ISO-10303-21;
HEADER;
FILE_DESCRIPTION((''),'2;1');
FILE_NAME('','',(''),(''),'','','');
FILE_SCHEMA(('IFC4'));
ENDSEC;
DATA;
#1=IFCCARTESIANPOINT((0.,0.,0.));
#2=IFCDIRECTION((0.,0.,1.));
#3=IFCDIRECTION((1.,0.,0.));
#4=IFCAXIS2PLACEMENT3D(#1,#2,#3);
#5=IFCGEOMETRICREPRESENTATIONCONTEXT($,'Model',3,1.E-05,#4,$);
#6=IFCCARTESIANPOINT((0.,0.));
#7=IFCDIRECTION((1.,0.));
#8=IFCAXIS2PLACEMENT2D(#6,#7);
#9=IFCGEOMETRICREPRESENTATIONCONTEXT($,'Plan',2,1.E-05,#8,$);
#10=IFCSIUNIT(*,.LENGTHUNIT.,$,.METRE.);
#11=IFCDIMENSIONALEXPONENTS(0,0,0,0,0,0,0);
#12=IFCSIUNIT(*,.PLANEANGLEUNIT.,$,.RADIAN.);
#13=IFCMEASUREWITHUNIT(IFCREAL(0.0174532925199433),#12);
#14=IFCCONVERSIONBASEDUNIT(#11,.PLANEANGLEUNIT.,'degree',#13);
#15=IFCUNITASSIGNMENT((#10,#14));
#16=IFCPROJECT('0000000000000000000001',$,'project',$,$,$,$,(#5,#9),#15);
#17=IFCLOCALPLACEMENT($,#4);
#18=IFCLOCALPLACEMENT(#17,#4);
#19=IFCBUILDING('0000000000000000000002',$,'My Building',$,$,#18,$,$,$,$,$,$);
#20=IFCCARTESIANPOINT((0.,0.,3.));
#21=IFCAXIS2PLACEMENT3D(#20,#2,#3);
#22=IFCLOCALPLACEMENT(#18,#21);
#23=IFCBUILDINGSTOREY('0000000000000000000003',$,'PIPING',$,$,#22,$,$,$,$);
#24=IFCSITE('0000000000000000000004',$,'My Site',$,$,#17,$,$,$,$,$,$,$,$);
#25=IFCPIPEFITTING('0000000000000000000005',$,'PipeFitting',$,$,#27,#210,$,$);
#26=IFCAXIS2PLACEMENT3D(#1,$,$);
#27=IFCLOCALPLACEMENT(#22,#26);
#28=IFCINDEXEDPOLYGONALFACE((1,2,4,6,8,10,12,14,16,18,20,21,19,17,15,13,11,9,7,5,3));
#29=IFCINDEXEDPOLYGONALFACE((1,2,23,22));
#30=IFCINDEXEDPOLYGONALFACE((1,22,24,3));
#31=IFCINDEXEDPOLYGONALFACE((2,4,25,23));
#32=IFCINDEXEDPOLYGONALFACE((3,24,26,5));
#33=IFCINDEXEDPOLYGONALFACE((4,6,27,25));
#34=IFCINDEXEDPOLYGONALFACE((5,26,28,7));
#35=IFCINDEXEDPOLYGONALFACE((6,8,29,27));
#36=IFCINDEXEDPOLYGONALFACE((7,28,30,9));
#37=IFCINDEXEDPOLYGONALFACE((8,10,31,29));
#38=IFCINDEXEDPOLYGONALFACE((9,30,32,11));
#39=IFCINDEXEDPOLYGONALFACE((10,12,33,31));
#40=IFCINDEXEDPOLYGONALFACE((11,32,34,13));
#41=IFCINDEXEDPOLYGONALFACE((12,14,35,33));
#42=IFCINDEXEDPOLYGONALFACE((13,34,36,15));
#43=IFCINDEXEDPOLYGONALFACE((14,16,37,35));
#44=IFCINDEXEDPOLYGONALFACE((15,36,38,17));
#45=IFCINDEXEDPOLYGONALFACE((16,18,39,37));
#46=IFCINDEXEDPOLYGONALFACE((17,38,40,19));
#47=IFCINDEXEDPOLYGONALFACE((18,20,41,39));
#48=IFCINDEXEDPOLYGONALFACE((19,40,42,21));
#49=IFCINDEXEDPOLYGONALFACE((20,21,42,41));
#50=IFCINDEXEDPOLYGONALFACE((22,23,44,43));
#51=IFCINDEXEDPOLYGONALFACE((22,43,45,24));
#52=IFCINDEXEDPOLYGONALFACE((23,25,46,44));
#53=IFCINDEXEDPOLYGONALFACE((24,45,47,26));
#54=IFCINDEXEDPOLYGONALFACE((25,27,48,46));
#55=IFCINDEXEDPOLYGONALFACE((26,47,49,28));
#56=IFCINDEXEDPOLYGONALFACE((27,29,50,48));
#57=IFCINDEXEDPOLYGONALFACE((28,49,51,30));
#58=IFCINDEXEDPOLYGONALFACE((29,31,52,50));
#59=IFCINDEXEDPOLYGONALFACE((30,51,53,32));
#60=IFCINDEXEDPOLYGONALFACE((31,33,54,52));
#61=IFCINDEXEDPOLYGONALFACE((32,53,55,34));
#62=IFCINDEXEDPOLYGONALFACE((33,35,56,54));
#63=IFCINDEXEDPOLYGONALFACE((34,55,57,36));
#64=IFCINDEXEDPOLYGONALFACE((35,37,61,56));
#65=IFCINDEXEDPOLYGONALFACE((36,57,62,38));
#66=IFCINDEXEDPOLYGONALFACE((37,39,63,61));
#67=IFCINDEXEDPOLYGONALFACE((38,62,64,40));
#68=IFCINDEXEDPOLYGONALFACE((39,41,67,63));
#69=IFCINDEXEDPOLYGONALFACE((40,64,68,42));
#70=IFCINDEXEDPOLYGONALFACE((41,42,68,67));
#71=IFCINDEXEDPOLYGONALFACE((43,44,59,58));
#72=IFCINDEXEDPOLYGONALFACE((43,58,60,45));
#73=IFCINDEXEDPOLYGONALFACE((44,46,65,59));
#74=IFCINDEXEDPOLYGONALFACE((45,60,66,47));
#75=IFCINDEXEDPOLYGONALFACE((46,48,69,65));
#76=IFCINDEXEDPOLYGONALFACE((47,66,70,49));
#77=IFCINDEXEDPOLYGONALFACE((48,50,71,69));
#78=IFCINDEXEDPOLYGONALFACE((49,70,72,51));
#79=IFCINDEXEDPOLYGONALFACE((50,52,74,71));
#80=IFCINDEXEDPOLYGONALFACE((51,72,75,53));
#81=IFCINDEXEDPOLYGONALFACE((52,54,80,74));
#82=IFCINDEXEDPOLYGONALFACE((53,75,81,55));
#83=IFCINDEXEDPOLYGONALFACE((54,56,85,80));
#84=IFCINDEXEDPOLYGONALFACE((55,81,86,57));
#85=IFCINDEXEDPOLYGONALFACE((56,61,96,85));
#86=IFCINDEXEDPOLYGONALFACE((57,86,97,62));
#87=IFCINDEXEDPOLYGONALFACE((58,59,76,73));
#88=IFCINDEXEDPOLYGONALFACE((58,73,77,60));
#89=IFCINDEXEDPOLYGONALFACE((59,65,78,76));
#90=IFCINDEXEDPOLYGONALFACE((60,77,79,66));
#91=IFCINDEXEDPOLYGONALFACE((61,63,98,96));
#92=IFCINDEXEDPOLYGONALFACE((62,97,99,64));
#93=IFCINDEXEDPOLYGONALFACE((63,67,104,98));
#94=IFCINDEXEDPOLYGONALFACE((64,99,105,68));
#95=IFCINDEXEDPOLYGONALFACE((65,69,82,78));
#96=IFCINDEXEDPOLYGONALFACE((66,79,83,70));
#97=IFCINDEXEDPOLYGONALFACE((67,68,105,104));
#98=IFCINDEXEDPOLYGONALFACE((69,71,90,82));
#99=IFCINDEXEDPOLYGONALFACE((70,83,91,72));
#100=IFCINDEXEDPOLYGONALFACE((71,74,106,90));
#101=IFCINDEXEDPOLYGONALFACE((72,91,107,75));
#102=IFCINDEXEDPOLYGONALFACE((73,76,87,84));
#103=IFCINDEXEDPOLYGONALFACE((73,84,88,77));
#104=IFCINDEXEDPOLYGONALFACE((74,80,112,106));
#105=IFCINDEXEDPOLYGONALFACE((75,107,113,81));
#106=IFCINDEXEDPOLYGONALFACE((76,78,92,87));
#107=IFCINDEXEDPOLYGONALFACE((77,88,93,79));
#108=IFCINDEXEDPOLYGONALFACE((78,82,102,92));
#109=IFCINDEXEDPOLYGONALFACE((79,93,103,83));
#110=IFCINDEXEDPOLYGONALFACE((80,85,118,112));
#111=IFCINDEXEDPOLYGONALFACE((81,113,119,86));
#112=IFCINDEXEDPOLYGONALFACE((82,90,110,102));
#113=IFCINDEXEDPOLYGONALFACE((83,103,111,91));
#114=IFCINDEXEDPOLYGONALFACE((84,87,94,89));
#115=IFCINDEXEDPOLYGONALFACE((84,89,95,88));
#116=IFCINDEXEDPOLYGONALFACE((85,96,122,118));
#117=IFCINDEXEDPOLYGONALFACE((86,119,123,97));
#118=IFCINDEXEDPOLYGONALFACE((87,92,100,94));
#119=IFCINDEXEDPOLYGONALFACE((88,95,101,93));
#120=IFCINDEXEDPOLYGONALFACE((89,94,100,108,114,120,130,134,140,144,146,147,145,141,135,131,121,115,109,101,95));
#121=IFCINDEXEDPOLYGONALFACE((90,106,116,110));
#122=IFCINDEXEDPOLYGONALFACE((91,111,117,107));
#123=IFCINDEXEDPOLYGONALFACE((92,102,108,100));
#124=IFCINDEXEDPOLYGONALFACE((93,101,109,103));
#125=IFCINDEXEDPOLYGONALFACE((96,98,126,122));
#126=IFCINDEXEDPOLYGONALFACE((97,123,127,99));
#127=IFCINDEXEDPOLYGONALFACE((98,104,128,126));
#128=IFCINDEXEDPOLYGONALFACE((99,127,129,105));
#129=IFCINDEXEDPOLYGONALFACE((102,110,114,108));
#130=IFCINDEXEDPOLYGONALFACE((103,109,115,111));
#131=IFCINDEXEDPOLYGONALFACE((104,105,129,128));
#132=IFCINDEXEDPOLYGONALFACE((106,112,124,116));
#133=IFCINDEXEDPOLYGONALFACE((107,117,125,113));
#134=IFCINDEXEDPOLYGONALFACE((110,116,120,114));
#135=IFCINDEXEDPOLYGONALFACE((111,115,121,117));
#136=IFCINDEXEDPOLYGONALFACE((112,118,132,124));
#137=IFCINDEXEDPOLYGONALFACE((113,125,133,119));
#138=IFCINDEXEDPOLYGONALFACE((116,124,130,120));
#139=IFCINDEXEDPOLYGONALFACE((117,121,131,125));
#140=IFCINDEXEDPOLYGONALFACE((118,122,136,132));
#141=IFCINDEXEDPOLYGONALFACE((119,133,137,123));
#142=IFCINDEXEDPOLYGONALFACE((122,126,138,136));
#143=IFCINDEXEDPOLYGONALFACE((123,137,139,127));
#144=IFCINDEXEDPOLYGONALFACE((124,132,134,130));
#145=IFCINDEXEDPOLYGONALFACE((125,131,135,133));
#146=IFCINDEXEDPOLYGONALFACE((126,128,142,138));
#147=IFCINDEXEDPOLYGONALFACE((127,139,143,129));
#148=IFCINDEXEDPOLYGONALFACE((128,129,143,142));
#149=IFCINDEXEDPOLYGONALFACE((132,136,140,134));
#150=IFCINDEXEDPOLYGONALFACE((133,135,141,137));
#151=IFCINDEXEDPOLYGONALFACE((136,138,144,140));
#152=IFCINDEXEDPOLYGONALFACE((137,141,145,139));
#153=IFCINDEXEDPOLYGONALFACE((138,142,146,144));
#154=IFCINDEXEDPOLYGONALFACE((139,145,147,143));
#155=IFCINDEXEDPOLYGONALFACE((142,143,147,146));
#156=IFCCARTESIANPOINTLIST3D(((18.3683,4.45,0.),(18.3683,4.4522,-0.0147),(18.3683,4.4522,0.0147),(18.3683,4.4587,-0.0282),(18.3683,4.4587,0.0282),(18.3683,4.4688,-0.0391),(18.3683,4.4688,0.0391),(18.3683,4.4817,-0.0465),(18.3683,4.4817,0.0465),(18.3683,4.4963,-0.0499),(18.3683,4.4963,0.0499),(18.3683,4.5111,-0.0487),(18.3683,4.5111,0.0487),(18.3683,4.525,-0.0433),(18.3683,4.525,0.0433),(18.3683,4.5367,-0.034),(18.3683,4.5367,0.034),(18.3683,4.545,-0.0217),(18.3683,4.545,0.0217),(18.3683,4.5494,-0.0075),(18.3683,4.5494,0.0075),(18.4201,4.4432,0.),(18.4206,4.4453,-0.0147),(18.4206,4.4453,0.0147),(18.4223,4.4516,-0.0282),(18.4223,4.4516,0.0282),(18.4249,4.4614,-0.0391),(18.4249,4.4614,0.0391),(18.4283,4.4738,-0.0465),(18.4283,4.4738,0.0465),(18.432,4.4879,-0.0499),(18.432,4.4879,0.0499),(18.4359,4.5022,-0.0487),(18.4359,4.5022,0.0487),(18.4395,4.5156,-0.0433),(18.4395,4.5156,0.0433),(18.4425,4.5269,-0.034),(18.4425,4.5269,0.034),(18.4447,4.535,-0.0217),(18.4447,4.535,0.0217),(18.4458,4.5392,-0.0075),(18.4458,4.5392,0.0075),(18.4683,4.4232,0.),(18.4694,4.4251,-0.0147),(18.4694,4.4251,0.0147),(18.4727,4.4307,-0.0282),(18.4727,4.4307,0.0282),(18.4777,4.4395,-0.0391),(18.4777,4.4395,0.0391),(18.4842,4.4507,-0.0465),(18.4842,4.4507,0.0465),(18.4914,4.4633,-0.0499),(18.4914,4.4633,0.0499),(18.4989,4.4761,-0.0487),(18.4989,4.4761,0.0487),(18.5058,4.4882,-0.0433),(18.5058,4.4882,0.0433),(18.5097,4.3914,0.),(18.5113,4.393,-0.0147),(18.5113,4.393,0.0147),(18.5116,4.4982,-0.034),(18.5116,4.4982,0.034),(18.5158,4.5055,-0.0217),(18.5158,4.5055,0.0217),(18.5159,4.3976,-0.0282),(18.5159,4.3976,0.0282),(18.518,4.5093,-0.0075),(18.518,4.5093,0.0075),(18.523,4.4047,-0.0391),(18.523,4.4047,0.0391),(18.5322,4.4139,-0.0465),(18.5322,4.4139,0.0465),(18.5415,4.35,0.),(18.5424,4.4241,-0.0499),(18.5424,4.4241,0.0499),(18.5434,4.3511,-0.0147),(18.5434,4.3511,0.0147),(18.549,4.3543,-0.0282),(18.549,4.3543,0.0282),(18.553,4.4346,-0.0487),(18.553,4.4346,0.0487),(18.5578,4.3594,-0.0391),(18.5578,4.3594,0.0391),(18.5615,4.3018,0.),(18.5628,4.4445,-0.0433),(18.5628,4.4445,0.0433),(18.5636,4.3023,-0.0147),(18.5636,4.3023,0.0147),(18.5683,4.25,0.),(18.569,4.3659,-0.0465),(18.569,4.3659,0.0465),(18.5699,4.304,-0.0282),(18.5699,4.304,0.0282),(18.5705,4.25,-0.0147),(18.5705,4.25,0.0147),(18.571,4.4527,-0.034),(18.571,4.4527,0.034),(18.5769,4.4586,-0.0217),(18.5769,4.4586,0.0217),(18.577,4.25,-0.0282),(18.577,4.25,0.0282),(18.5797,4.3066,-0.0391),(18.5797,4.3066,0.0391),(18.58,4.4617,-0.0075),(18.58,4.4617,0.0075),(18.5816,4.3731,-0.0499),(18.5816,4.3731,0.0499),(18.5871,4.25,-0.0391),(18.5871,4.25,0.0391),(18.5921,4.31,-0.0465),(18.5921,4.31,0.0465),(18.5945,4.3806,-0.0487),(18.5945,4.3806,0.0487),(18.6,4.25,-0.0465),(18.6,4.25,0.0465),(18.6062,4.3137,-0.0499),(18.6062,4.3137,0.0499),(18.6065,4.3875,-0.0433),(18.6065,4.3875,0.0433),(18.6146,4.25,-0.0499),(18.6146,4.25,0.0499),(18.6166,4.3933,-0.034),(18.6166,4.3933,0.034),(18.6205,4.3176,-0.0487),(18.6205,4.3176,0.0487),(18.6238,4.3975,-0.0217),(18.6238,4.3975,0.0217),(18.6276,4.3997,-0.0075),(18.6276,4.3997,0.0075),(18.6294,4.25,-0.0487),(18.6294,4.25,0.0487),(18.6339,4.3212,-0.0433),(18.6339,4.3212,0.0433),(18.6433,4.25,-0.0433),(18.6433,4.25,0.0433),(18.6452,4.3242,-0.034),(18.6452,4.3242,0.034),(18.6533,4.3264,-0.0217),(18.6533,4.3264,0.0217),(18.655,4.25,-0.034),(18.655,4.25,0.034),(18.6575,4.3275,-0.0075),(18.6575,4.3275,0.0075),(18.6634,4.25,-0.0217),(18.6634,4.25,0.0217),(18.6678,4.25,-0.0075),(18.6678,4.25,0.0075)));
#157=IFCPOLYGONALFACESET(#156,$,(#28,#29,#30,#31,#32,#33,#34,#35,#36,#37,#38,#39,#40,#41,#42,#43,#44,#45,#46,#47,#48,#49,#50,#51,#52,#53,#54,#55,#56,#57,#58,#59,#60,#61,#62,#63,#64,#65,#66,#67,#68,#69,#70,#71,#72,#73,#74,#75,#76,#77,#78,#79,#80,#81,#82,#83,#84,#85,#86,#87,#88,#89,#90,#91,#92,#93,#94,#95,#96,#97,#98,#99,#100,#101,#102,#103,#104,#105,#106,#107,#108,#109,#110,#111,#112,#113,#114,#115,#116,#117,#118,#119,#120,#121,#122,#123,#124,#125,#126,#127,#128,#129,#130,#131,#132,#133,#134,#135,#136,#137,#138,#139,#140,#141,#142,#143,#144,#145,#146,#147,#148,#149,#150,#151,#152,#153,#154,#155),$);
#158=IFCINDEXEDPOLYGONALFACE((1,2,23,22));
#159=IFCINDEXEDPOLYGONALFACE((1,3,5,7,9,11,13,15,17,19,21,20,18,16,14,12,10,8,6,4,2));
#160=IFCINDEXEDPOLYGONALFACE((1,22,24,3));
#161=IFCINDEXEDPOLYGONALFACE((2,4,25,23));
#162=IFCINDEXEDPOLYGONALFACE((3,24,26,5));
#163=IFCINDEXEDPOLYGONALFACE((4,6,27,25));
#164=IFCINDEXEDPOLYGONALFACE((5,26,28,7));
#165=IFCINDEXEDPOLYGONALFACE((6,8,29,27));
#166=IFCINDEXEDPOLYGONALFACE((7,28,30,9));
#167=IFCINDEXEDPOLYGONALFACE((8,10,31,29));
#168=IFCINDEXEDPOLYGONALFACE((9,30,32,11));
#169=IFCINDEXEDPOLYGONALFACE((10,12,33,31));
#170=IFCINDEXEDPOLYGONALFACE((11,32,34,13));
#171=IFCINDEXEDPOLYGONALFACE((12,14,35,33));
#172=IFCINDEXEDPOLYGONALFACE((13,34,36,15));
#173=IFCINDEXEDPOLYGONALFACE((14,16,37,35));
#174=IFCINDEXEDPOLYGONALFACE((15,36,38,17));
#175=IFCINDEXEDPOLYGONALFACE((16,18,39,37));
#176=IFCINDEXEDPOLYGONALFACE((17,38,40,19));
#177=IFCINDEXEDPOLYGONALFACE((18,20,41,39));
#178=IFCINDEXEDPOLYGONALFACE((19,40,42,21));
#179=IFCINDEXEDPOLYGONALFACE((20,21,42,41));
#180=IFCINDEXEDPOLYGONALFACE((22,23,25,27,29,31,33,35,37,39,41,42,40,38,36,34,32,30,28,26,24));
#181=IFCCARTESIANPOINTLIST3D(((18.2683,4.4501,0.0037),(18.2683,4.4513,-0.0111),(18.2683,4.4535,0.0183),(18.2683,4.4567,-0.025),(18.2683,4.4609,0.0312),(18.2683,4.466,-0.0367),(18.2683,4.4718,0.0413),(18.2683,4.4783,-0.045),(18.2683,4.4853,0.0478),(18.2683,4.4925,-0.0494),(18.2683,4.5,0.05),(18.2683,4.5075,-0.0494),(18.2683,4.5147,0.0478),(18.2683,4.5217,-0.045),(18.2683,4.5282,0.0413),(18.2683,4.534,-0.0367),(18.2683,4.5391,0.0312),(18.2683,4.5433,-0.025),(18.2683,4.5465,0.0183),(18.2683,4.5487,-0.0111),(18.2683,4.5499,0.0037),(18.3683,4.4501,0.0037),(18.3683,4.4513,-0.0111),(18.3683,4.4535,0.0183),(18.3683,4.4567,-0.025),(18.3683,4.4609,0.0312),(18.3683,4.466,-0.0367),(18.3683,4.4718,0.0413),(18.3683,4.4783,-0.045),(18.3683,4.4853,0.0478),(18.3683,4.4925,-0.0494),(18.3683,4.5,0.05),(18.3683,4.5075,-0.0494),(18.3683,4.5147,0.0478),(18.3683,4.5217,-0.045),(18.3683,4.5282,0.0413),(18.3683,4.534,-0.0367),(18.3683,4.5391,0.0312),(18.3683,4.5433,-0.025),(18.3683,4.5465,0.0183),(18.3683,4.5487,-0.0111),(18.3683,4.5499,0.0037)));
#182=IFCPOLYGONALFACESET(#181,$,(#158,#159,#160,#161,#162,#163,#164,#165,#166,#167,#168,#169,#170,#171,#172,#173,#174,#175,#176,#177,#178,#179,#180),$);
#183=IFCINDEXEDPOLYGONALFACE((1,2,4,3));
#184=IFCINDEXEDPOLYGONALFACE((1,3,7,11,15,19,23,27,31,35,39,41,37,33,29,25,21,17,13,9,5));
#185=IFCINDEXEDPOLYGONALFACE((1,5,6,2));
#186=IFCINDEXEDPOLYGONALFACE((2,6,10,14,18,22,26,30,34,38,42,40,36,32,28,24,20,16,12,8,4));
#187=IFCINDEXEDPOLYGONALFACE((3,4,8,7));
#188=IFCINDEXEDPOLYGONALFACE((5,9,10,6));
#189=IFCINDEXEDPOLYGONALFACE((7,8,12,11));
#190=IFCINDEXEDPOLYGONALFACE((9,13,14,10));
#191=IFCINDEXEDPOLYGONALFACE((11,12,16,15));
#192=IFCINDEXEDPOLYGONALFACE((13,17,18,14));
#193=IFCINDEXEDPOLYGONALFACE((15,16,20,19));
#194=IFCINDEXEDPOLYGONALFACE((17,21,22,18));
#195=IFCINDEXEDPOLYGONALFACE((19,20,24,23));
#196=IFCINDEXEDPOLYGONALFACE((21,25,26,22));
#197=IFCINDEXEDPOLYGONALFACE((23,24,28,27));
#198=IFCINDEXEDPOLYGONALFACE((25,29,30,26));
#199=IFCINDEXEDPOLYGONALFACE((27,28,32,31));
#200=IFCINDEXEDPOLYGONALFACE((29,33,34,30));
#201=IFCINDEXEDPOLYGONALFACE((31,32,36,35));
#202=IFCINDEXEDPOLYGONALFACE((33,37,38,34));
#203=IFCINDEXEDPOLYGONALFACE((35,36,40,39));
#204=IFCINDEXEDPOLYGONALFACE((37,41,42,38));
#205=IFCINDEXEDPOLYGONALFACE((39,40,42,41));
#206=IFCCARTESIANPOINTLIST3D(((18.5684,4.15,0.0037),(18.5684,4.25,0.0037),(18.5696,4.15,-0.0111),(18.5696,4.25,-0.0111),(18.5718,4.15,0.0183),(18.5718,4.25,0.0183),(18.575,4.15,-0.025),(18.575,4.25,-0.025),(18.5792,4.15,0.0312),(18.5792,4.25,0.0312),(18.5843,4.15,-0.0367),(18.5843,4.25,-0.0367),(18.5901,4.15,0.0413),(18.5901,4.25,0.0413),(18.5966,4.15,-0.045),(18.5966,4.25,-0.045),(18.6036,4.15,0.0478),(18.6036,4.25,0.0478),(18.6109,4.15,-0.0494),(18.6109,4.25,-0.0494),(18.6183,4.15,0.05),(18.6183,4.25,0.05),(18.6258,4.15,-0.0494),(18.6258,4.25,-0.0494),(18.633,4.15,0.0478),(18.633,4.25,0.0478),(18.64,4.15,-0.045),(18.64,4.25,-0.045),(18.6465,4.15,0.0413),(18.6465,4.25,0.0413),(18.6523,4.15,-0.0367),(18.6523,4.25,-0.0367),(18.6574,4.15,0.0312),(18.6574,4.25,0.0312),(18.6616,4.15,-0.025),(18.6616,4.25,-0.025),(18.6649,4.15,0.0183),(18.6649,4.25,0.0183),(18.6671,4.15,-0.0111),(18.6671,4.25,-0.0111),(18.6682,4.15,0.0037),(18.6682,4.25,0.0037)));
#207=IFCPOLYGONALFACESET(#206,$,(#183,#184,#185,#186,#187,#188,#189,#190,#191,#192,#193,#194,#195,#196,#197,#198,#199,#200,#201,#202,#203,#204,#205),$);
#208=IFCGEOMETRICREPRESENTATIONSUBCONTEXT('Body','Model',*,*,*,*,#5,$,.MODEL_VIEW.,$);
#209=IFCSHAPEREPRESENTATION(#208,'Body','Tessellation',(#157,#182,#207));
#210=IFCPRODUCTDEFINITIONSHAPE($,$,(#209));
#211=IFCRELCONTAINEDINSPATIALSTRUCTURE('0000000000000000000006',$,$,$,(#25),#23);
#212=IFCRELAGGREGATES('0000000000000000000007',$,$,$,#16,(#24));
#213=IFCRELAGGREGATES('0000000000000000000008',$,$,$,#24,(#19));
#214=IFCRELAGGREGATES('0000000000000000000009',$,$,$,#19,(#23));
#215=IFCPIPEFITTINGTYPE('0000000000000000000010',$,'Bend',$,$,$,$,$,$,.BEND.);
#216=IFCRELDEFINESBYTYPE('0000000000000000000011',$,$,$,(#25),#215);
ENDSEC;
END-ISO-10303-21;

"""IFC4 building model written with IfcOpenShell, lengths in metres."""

from ifc_helpers import new_model, entity, si_unit, converted_unit, frame, origin_with_axes, origin_2d_with_axis, place, context, subcontext, project, spatial, circle, extrude, source, transform, mapped, type_object, type_shapes, element, save


model = new_model("IFC4")

# Units and contexts
model_context = context("Model", 3, precision=1e-05, world=origin_with_axes())
plan_context = context("Plan", 2, precision=1e-05, world=origin_2d_with_axis())
body_context = subcontext(model_context, "Body", "Model", "MODEL_VIEW")
ifc_project = project(units=[si_unit("LENGTHUNIT", "METRE"), converted_unit("PLANEANGLEUNIT", "degree", entity("IfcReal", 0.0174532925199433), si_unit("PLANEANGLEUNIT", "RADIAN"), dimensions=[0, 0, 0, 0, 0, 0, 0])], contexts=[model_context, plan_context])

# Site, building, storey
site_placement = place(None, origin_with_axes())
site = spatial("IfcSite", under=ifc_project, at=site_placement, Name="My Site")
building_placement = place(site_placement, origin_with_axes())
building = spatial("IfcBuilding", under=site, at=building_placement, Name="My Building")
storey_placement = place(building_placement, frame((0.0, 0.0, 3.0), z_axis=(0.0, 0.0, 1.0), x_axis=(1.0, 0.0, 0.0)))
storey = spatial("IfcBuildingStorey", under=building, at=storey_placement, Name="PIPING")

# Pipe fitting
pipe_fitting_type_1 = type_object("IfcPipeFittingType", Name="Bend", PredefinedType="BEND")
shared_shape = source(origin_with_axes(), body_context, "Body", "SolidModel", [
    entity("IfcSweptDiskSolid", entity("IfcIndexedPolyCurve", entity("IfcCartesianPointList3D", [[0.0, 0.0, -0.1], [0.0, -0.0732, -0.2768], [0.0, -0.25, -0.35]]), [entity("IfcArcIndex", [1, 2, 3])]), 0.05),
    extrude(circle(Radius=0.05), origin_with_axes(), (0.0, 0.0, -1.0), 0.1),
    extrude(circle(Radius=0.05), frame((0.0, -0.25, -0.35), z_axis=(0.0, -1.0, 0.0), x_axis=(1.0, 0.0, 0.0)), (0.0, 0.0, 1.0), 0.1),
])
type_shapes(pipe_fitting_type_1, [shared_shape])
for number, where, z_axis, x_axis, name in (
    (1, (18.2683, 4.5, 0.0), (-1.0, 0.0, 0.0), (0.0, 0.0, 1.0), "PipeFitting"),
):
    element("IfcPipeFitting", number, at=place(storey_placement, frame(where, z_axis=z_axis, x_axis=x_axis)), inside=storey, type_object=pipe_fitting_type_1, Name=name, context=body_context, shape_type="MappedRepresentation", body=[
        mapped(shared_shape, transform((0.0, 0.0, 0.0), x_axis=(1.0, 0.0, 0.0), y_axis=(0.0, 1.0, 0.0), z_axis=(0.0, 0.0, 1.0), scale=1.0)),
    ])

save(model, "model.ifc")
